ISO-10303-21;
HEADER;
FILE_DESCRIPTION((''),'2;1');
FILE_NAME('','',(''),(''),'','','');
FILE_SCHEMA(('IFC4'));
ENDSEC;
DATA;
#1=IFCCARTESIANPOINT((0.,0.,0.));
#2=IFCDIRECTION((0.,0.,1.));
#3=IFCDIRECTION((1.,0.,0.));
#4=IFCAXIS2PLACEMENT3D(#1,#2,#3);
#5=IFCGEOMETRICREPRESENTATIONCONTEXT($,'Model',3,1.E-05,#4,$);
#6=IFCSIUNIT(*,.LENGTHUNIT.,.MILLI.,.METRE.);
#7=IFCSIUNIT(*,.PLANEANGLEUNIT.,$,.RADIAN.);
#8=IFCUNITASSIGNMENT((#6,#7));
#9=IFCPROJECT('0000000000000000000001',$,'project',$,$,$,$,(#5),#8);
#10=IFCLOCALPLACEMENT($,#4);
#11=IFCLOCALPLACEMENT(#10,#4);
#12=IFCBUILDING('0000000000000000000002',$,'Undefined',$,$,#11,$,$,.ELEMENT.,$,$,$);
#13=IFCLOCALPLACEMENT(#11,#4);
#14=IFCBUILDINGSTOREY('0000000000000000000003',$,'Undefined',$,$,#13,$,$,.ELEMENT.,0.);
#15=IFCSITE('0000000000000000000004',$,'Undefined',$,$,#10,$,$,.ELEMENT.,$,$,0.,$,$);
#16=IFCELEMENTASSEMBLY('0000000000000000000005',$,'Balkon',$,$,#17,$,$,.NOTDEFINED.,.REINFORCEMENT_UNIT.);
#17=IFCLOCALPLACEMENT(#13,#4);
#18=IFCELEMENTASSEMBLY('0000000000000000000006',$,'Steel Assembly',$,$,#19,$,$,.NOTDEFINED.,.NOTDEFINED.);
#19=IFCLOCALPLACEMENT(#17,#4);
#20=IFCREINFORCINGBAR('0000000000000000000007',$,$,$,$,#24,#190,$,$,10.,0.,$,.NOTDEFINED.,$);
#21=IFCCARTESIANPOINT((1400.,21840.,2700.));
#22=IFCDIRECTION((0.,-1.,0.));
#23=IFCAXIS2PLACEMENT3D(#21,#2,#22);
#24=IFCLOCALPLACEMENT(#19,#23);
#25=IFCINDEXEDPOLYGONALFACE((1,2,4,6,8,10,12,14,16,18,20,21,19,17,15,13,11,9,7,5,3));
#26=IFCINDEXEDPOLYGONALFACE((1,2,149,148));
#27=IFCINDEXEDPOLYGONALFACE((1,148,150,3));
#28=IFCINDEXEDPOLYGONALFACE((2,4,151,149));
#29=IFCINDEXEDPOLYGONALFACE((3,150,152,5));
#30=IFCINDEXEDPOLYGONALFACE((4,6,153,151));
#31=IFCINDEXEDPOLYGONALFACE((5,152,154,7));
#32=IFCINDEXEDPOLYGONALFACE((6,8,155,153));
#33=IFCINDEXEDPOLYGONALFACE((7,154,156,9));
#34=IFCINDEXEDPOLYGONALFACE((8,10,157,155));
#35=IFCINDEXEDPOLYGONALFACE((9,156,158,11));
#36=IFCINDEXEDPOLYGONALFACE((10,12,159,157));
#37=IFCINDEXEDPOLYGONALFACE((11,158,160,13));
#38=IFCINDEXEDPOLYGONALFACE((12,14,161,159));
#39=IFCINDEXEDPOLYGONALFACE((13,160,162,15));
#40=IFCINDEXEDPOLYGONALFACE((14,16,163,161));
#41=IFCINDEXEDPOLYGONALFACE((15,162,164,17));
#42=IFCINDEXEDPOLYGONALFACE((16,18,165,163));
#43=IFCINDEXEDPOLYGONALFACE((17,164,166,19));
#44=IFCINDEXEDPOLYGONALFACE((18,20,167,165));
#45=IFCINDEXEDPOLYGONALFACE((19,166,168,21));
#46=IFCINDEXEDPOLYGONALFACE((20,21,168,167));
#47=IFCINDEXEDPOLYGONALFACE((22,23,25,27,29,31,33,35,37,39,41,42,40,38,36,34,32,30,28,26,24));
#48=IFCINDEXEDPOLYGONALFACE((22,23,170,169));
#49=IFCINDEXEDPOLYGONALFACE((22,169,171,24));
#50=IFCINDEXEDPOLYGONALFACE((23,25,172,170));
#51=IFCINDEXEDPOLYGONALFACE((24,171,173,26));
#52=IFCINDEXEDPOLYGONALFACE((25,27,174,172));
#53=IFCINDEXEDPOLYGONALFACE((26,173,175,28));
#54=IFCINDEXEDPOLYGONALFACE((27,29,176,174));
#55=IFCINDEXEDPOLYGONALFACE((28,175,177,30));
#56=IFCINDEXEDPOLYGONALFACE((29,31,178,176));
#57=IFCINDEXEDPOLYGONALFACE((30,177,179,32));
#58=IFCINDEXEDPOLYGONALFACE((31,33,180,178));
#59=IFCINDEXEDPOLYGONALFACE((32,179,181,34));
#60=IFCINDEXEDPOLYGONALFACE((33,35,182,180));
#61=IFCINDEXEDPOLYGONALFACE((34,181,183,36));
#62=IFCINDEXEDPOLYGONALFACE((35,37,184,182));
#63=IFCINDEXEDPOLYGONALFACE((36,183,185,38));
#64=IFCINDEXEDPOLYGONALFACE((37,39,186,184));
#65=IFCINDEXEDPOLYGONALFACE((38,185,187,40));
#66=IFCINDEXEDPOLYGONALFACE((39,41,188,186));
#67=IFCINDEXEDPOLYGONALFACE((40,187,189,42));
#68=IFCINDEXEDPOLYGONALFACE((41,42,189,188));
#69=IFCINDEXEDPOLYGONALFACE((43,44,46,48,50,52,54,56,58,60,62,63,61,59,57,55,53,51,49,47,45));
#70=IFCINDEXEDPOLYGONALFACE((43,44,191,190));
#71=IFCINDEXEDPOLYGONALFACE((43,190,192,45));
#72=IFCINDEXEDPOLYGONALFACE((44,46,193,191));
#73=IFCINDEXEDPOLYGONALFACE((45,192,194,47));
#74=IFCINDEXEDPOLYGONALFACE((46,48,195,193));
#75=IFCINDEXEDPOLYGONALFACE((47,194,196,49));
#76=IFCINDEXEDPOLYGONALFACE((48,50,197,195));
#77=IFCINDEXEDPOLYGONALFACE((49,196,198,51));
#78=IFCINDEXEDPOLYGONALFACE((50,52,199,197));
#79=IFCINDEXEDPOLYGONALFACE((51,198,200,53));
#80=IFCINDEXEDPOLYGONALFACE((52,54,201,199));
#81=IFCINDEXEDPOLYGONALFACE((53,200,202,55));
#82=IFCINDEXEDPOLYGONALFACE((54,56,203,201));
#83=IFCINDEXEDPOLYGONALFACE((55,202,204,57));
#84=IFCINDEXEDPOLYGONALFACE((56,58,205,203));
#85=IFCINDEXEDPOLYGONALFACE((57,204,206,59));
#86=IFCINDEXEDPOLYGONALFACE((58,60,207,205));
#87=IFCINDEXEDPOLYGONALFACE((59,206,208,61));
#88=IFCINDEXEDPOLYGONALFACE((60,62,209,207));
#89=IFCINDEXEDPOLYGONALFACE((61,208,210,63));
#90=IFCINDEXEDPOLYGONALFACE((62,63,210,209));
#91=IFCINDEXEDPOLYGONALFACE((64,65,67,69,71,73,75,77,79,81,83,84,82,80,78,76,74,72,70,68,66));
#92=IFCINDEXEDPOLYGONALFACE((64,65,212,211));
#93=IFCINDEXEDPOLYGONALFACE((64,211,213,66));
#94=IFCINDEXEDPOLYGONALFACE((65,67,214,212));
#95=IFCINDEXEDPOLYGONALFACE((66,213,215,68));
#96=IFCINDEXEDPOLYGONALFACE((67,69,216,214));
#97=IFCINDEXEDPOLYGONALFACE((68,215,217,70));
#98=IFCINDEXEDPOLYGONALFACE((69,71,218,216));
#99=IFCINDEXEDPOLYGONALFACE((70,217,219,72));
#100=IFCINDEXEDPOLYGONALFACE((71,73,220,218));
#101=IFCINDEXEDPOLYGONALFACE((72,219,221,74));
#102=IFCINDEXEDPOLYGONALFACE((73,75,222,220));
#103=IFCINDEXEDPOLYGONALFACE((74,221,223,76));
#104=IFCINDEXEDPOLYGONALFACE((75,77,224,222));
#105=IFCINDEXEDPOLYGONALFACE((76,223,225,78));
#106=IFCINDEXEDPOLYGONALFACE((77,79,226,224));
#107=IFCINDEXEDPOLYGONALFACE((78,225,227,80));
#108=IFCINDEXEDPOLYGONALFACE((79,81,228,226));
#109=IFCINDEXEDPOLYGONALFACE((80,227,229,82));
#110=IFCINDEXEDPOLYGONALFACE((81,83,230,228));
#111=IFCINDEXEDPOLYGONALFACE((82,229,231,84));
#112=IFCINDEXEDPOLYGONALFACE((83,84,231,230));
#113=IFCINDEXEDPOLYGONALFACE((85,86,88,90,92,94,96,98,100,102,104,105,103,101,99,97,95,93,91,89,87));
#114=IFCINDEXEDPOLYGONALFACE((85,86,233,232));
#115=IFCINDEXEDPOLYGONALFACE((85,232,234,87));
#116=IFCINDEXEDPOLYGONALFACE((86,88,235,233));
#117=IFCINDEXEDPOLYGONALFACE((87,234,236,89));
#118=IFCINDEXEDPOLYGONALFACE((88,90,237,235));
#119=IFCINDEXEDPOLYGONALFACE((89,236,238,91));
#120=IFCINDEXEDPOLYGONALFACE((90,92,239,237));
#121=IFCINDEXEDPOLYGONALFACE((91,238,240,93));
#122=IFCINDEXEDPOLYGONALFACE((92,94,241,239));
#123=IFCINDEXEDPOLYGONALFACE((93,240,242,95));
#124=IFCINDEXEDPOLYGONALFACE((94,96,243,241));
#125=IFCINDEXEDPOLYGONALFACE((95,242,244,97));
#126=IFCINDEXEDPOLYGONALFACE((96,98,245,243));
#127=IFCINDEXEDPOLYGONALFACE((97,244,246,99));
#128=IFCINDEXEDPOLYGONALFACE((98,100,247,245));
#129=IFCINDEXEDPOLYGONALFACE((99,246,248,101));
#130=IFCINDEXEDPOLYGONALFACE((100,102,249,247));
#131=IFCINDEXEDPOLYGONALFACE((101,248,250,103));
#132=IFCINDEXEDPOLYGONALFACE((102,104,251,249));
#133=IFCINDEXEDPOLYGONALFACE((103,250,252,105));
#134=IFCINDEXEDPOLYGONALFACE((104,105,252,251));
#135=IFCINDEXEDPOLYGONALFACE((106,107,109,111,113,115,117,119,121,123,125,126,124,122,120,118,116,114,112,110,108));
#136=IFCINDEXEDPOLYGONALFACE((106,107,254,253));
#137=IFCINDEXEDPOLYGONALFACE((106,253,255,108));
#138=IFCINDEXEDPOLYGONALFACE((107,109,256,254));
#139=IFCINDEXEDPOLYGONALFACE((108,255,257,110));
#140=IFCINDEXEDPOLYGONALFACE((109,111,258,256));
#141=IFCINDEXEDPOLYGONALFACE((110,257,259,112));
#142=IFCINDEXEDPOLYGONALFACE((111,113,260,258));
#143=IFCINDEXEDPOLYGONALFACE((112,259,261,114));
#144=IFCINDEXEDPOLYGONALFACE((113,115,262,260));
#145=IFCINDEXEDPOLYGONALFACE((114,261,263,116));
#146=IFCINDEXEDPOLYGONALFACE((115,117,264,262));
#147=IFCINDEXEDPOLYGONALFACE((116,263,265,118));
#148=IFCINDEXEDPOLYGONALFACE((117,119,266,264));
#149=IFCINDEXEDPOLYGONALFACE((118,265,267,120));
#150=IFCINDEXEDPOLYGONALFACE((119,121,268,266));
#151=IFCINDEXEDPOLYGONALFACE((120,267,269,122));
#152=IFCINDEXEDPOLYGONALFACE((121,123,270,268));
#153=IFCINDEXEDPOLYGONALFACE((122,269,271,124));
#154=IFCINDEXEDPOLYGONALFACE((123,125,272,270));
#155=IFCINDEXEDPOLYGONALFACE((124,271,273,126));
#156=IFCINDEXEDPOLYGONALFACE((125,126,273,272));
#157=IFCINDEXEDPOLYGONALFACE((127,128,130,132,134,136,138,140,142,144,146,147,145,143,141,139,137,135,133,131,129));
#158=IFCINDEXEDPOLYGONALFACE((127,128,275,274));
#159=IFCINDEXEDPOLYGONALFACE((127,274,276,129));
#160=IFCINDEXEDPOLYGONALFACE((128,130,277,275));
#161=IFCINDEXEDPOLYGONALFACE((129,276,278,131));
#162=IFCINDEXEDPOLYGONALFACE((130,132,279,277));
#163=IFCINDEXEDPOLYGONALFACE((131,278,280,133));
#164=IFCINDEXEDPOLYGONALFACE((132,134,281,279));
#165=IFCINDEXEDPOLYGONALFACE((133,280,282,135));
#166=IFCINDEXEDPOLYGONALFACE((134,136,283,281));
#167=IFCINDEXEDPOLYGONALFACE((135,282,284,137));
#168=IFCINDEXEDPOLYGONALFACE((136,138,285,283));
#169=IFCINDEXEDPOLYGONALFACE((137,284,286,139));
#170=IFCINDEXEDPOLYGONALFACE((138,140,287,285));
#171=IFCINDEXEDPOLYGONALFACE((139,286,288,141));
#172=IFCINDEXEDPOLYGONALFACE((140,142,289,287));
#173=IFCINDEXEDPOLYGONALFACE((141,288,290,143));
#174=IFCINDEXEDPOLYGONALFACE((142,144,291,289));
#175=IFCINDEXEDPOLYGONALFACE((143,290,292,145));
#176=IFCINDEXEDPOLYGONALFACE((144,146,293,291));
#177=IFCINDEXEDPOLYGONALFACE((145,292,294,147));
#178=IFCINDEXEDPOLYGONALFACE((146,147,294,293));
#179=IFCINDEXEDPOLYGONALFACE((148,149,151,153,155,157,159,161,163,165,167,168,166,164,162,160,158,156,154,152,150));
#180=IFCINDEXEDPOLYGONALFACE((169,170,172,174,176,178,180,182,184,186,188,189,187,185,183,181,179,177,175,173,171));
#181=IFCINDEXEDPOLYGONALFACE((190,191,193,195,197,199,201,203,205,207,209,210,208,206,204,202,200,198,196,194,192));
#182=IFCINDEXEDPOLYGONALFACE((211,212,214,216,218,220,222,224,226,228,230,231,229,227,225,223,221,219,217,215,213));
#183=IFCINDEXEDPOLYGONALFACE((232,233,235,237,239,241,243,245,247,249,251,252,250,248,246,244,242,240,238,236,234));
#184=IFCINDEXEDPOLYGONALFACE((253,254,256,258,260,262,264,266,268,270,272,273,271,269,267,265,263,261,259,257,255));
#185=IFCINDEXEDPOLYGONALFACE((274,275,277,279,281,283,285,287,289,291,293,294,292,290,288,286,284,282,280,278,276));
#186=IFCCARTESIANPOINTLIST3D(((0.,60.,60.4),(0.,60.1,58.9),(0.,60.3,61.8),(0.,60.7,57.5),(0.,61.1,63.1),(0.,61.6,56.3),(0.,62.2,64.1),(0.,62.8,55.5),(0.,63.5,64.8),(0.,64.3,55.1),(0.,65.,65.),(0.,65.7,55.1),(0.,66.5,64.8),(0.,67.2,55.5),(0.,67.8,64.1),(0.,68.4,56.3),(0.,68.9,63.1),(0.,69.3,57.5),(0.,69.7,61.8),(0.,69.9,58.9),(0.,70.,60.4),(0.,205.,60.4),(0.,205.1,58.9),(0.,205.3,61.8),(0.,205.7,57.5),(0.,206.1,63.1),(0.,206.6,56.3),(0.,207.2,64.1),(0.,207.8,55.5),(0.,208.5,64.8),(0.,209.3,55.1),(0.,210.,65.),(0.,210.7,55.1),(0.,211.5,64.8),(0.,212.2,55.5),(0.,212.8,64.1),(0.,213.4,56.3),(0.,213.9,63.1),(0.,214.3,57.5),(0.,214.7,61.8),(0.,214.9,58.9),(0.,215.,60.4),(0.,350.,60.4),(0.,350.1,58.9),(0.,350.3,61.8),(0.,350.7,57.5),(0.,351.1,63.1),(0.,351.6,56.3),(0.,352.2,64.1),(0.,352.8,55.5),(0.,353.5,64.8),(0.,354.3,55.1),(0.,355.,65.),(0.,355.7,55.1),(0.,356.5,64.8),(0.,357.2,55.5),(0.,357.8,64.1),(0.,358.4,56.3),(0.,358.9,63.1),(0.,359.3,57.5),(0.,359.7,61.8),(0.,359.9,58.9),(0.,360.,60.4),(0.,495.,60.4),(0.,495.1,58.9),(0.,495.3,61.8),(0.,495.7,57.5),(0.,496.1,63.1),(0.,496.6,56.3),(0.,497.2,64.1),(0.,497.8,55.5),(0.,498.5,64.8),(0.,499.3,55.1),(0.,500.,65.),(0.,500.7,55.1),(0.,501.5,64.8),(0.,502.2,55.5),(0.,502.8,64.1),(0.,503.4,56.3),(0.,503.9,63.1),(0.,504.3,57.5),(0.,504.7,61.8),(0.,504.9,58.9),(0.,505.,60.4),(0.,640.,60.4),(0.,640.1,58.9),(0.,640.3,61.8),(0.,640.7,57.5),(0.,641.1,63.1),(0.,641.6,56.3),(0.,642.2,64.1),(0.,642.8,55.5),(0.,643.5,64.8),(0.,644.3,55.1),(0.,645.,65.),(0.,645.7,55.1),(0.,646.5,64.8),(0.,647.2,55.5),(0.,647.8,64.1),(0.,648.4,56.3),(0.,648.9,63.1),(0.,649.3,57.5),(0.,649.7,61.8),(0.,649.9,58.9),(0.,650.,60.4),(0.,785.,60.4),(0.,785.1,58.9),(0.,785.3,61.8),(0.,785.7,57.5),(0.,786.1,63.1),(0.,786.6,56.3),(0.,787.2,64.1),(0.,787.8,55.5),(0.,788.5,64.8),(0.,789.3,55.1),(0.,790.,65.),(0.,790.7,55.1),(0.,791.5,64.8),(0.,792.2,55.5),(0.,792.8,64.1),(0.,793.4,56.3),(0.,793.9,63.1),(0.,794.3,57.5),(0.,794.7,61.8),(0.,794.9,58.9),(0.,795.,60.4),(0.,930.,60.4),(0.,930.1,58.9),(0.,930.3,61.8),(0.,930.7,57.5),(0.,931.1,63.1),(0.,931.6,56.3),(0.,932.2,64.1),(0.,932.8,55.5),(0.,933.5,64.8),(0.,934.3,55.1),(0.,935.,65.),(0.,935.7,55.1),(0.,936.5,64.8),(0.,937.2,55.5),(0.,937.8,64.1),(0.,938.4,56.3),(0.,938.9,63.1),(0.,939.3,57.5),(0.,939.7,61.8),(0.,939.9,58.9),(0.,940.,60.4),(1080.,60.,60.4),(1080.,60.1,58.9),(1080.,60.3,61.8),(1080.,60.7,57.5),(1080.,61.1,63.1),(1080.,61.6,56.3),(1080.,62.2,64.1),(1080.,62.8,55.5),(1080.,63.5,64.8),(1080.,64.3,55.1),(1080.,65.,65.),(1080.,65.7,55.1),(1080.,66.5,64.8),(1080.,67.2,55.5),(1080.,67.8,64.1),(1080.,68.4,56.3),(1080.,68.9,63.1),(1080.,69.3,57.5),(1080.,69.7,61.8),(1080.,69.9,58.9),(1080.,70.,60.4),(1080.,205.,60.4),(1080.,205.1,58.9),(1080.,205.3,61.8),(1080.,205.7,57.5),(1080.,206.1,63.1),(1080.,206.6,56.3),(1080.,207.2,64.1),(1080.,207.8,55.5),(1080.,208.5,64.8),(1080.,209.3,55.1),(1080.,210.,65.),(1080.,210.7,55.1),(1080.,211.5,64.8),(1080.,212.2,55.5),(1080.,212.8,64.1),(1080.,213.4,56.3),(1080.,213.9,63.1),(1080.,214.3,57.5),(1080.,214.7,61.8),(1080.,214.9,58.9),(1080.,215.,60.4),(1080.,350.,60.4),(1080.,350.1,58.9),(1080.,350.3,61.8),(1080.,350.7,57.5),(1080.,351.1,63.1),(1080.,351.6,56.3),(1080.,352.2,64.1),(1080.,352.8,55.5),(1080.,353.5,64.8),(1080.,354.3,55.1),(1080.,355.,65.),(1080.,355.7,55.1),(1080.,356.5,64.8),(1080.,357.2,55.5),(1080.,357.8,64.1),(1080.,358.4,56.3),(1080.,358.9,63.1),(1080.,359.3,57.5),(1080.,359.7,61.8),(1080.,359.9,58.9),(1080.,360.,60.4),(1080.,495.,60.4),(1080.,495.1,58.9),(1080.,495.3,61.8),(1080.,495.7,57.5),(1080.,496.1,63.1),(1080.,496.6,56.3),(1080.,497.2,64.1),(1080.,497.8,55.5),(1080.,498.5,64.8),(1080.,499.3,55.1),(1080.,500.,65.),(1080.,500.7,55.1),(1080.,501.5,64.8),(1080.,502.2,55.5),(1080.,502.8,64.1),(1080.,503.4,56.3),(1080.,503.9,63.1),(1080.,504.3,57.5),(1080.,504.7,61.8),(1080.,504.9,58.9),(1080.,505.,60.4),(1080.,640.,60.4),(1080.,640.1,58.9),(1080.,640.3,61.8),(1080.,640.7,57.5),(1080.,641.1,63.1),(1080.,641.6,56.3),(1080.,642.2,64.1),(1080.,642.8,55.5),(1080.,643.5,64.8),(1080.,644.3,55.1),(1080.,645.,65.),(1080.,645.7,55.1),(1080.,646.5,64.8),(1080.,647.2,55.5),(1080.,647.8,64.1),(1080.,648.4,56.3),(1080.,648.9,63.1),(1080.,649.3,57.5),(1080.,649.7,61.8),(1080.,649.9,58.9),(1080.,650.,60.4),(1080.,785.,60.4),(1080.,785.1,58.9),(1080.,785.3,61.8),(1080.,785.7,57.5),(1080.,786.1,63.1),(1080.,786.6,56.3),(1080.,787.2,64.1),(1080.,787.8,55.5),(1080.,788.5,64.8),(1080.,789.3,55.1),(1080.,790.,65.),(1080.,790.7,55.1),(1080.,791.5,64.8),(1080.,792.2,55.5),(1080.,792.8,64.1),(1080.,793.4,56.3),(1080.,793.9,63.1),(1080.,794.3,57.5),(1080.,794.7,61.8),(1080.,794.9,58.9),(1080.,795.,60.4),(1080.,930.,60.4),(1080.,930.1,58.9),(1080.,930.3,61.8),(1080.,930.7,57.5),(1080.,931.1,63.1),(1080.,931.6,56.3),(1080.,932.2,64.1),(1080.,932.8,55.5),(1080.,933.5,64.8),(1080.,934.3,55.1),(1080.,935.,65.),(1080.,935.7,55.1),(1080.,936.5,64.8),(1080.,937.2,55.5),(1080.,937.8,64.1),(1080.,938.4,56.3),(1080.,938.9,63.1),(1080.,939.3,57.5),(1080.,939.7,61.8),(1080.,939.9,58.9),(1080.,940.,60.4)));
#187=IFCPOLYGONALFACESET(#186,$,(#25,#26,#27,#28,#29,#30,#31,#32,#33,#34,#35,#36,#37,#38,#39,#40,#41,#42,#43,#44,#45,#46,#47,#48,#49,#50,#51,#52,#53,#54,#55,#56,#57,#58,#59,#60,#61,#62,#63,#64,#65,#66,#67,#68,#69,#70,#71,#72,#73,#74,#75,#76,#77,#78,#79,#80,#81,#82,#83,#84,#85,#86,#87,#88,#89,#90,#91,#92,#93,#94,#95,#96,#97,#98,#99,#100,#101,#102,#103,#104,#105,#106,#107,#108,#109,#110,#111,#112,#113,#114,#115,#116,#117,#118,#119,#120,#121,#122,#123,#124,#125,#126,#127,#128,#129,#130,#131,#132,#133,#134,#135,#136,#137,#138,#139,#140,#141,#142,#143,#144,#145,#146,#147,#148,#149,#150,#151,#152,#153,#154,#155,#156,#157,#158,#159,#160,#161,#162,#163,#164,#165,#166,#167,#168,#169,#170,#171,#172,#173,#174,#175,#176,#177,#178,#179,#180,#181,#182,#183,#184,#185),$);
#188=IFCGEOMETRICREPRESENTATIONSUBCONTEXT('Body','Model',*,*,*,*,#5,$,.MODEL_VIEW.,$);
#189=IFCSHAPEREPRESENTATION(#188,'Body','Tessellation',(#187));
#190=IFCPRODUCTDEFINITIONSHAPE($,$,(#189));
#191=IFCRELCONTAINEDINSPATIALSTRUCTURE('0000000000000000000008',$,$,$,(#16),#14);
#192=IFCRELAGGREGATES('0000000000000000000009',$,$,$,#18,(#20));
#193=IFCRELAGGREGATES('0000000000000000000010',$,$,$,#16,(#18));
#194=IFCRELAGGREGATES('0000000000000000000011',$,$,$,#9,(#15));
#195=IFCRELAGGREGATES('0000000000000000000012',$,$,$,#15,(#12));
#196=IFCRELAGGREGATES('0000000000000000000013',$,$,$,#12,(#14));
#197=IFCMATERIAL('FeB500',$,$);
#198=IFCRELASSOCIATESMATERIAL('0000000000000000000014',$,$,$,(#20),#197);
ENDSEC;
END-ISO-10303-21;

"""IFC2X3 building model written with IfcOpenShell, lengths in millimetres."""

from ifc_helpers import new_model, entity, si_unit, frame, origin_with_axes, place, context, subcontext, project, spatial, source, transform, mapped, material, element, aggregate, save


model = new_model("IFC2X3")

# Units and contexts
model_context = context("Model", 3, precision=1e-05, world=origin_with_axes())
body_context = subcontext(model_context, "Body", "Model", "MODEL_VIEW")
ifc_project = project(units=[si_unit("LENGTHUNIT", "METRE", prefix="MILLI"), si_unit("PLANEANGLEUNIT", "RADIAN")], contexts=[model_context])

# Site, building, storey
site_placement = place(None, origin_with_axes())
site = spatial("IfcSite", under=ifc_project, at=site_placement, Name="Undefined", CompositionType="ELEMENT", RefElevation=0.0)
building_placement = place(site_placement, origin_with_axes())
building = spatial("IfcBuilding", under=site, at=building_placement, Name="Undefined", CompositionType="ELEMENT")
storey_placement = place(building_placement, origin_with_axes())
storey = spatial("IfcBuildingStorey", under=building, at=storey_placement, Name="Undefined", CompositionType="ELEMENT", Elevation=0.0)

# Element assemblies, reinforcing bar
assembly_1_placement = place(storey_placement, origin_with_axes())
assembly_1 = element("IfcElementAssembly", 1, at=assembly_1_placement, inside=storey, Name="Balkon", AssemblyPlace="NOTDEFINED", PredefinedType="REINFORCEMENT_UNIT")
assembly_2_placement = place(assembly_1_placement, origin_with_axes())
assembly_2 = element("IfcElementAssembly", 2, at=assembly_2_placement, Name="Steel Assembly", AssemblyPlace="NOTDEFINED", PredefinedType="NOTDEFINED")
ifc_material_1 = material(Name="FeB500")
shared_shape_1 = source(origin_with_axes(), body_context, "Body", "AdvancedSweptSolid", [
    entity("IfcSweptDiskSolid", entity("IfcTrimmedCurve", entity("IfcLine", entity("IfcCartesianPoint", [0.0, 0.0, 0.0]), entity("IfcVector", entity("IfcDirection", [1.0, 0.0, 0.0]), 1.0)), [entity("IfcParameterValue", 0.0)], [entity("IfcParameterValue", 1080.0)], True, "PARAMETER"), 5.0, None, 0.0, 1080.0),
])
shared_shape_2 = source(origin_with_axes(), body_context, "Body", "AdvancedSweptSolid", [
    entity("IfcSweptDiskSolid", entity("IfcTrimmedCurve", entity("IfcLine", entity("IfcCartesianPoint", [0.0, 0.0, 0.0]), entity("IfcVector", entity("IfcDirection", [1.0, 0.0, 0.0]), 1.0)), [entity("IfcParameterValue", 0.0)], [entity("IfcParameterValue", 1080.0)], True, "PARAMETER"), 5.0, None, 0.0, 1080.0),
])
shared_shape_3 = source(origin_with_axes(), body_context, "Body", "AdvancedSweptSolid", [
    entity("IfcSweptDiskSolid", entity("IfcTrimmedCurve", entity("IfcLine", entity("IfcCartesianPoint", [0.0, 0.0, 0.0]), entity("IfcVector", entity("IfcDirection", [1.0, 0.0, 0.0]), 1.0)), [entity("IfcParameterValue", 0.0)], [entity("IfcParameterValue", 1080.0)], True, "PARAMETER"), 5.0, None, 0.0, 1080.0),
])
shared_shape_4 = source(origin_with_axes(), body_context, "Body", "AdvancedSweptSolid", [
    entity("IfcSweptDiskSolid", entity("IfcTrimmedCurve", entity("IfcLine", entity("IfcCartesianPoint", [0.0, 0.0, 0.0]), entity("IfcVector", entity("IfcDirection", [1.0, 0.0, 0.0]), 1.0)), [entity("IfcParameterValue", 0.0)], [entity("IfcParameterValue", 1080.0)], True, "PARAMETER"), 5.0, None, 0.0, 1080.0),
])
shared_shape_5 = source(origin_with_axes(), body_context, "Body", "AdvancedSweptSolid", [
    entity("IfcSweptDiskSolid", entity("IfcTrimmedCurve", entity("IfcLine", entity("IfcCartesianPoint", [0.0, 0.0, 0.0]), entity("IfcVector", entity("IfcDirection", [1.0, 0.0, 0.0]), 1.0)), [entity("IfcParameterValue", 0.0)], [entity("IfcParameterValue", 1080.0)], True, "PARAMETER"), 5.0, None, 0.0, 1080.0),
])
shared_shape_6 = source(origin_with_axes(), body_context, "Body", "AdvancedSweptSolid", [
    entity("IfcSweptDiskSolid", entity("IfcTrimmedCurve", entity("IfcLine", entity("IfcCartesianPoint", [0.0, 0.0, 0.0]), entity("IfcVector", entity("IfcDirection", [1.0, 0.0, 0.0]), 1.0)), [entity("IfcParameterValue", 0.0)], [entity("IfcParameterValue", 1080.0)], True, "PARAMETER"), 5.0, None, 0.0, 1080.0),
])
shared_shape_7 = source(origin_with_axes(), body_context, "Body", "AdvancedSweptSolid", [
    entity("IfcSweptDiskSolid", entity("IfcTrimmedCurve", entity("IfcLine", entity("IfcCartesianPoint", [0.0, 0.0, 0.0]), entity("IfcVector", entity("IfcDirection", [1.0, 0.0, 0.0]), 1.0)), [entity("IfcParameterValue", 0.0)], [entity("IfcParameterValue", 1080.0)], True, "PARAMETER"), 5.0, None, 0.0, 1080.0),
])
reinforcing_bar_1_placement = place(assembly_2_placement, frame((1400.0, 21840.0, 2700.0), z_axis=(0.0, 0.0, 1.0), x_axis=(0.0, -1.0, 0.0)))
reinforcing_bar_1 = element("IfcReinforcingBar", 3, at=reinforcing_bar_1_placement, material=ifc_material_1, BarRole="NOTDEFINED", CrossSectionArea=0.0, NominalDiameter=10.0, context=body_context, shape_type="MappedRepresentation", body=[
    mapped(shared_shape_1, transform((0.0, 65.0, 60.0))),
    mapped(shared_shape_2, transform((0.0, 210.0, 60.0))),
    mapped(shared_shape_3, transform((0.0, 355.0, 60.0))),
    mapped(shared_shape_4, transform((0.0, 500.0, 60.0))),
    mapped(shared_shape_5, transform((0.0, 645.0, 60.0))),
    mapped(shared_shape_6, transform((0.0, 790.0, 60.0))),
    mapped(shared_shape_7, transform((0.0, 935.0, 60.0))),
])
aggregate(assembly_2, [reinforcing_bar_1])
aggregate(assembly_1, [assembly_2])

save(model, "model.ifc")
